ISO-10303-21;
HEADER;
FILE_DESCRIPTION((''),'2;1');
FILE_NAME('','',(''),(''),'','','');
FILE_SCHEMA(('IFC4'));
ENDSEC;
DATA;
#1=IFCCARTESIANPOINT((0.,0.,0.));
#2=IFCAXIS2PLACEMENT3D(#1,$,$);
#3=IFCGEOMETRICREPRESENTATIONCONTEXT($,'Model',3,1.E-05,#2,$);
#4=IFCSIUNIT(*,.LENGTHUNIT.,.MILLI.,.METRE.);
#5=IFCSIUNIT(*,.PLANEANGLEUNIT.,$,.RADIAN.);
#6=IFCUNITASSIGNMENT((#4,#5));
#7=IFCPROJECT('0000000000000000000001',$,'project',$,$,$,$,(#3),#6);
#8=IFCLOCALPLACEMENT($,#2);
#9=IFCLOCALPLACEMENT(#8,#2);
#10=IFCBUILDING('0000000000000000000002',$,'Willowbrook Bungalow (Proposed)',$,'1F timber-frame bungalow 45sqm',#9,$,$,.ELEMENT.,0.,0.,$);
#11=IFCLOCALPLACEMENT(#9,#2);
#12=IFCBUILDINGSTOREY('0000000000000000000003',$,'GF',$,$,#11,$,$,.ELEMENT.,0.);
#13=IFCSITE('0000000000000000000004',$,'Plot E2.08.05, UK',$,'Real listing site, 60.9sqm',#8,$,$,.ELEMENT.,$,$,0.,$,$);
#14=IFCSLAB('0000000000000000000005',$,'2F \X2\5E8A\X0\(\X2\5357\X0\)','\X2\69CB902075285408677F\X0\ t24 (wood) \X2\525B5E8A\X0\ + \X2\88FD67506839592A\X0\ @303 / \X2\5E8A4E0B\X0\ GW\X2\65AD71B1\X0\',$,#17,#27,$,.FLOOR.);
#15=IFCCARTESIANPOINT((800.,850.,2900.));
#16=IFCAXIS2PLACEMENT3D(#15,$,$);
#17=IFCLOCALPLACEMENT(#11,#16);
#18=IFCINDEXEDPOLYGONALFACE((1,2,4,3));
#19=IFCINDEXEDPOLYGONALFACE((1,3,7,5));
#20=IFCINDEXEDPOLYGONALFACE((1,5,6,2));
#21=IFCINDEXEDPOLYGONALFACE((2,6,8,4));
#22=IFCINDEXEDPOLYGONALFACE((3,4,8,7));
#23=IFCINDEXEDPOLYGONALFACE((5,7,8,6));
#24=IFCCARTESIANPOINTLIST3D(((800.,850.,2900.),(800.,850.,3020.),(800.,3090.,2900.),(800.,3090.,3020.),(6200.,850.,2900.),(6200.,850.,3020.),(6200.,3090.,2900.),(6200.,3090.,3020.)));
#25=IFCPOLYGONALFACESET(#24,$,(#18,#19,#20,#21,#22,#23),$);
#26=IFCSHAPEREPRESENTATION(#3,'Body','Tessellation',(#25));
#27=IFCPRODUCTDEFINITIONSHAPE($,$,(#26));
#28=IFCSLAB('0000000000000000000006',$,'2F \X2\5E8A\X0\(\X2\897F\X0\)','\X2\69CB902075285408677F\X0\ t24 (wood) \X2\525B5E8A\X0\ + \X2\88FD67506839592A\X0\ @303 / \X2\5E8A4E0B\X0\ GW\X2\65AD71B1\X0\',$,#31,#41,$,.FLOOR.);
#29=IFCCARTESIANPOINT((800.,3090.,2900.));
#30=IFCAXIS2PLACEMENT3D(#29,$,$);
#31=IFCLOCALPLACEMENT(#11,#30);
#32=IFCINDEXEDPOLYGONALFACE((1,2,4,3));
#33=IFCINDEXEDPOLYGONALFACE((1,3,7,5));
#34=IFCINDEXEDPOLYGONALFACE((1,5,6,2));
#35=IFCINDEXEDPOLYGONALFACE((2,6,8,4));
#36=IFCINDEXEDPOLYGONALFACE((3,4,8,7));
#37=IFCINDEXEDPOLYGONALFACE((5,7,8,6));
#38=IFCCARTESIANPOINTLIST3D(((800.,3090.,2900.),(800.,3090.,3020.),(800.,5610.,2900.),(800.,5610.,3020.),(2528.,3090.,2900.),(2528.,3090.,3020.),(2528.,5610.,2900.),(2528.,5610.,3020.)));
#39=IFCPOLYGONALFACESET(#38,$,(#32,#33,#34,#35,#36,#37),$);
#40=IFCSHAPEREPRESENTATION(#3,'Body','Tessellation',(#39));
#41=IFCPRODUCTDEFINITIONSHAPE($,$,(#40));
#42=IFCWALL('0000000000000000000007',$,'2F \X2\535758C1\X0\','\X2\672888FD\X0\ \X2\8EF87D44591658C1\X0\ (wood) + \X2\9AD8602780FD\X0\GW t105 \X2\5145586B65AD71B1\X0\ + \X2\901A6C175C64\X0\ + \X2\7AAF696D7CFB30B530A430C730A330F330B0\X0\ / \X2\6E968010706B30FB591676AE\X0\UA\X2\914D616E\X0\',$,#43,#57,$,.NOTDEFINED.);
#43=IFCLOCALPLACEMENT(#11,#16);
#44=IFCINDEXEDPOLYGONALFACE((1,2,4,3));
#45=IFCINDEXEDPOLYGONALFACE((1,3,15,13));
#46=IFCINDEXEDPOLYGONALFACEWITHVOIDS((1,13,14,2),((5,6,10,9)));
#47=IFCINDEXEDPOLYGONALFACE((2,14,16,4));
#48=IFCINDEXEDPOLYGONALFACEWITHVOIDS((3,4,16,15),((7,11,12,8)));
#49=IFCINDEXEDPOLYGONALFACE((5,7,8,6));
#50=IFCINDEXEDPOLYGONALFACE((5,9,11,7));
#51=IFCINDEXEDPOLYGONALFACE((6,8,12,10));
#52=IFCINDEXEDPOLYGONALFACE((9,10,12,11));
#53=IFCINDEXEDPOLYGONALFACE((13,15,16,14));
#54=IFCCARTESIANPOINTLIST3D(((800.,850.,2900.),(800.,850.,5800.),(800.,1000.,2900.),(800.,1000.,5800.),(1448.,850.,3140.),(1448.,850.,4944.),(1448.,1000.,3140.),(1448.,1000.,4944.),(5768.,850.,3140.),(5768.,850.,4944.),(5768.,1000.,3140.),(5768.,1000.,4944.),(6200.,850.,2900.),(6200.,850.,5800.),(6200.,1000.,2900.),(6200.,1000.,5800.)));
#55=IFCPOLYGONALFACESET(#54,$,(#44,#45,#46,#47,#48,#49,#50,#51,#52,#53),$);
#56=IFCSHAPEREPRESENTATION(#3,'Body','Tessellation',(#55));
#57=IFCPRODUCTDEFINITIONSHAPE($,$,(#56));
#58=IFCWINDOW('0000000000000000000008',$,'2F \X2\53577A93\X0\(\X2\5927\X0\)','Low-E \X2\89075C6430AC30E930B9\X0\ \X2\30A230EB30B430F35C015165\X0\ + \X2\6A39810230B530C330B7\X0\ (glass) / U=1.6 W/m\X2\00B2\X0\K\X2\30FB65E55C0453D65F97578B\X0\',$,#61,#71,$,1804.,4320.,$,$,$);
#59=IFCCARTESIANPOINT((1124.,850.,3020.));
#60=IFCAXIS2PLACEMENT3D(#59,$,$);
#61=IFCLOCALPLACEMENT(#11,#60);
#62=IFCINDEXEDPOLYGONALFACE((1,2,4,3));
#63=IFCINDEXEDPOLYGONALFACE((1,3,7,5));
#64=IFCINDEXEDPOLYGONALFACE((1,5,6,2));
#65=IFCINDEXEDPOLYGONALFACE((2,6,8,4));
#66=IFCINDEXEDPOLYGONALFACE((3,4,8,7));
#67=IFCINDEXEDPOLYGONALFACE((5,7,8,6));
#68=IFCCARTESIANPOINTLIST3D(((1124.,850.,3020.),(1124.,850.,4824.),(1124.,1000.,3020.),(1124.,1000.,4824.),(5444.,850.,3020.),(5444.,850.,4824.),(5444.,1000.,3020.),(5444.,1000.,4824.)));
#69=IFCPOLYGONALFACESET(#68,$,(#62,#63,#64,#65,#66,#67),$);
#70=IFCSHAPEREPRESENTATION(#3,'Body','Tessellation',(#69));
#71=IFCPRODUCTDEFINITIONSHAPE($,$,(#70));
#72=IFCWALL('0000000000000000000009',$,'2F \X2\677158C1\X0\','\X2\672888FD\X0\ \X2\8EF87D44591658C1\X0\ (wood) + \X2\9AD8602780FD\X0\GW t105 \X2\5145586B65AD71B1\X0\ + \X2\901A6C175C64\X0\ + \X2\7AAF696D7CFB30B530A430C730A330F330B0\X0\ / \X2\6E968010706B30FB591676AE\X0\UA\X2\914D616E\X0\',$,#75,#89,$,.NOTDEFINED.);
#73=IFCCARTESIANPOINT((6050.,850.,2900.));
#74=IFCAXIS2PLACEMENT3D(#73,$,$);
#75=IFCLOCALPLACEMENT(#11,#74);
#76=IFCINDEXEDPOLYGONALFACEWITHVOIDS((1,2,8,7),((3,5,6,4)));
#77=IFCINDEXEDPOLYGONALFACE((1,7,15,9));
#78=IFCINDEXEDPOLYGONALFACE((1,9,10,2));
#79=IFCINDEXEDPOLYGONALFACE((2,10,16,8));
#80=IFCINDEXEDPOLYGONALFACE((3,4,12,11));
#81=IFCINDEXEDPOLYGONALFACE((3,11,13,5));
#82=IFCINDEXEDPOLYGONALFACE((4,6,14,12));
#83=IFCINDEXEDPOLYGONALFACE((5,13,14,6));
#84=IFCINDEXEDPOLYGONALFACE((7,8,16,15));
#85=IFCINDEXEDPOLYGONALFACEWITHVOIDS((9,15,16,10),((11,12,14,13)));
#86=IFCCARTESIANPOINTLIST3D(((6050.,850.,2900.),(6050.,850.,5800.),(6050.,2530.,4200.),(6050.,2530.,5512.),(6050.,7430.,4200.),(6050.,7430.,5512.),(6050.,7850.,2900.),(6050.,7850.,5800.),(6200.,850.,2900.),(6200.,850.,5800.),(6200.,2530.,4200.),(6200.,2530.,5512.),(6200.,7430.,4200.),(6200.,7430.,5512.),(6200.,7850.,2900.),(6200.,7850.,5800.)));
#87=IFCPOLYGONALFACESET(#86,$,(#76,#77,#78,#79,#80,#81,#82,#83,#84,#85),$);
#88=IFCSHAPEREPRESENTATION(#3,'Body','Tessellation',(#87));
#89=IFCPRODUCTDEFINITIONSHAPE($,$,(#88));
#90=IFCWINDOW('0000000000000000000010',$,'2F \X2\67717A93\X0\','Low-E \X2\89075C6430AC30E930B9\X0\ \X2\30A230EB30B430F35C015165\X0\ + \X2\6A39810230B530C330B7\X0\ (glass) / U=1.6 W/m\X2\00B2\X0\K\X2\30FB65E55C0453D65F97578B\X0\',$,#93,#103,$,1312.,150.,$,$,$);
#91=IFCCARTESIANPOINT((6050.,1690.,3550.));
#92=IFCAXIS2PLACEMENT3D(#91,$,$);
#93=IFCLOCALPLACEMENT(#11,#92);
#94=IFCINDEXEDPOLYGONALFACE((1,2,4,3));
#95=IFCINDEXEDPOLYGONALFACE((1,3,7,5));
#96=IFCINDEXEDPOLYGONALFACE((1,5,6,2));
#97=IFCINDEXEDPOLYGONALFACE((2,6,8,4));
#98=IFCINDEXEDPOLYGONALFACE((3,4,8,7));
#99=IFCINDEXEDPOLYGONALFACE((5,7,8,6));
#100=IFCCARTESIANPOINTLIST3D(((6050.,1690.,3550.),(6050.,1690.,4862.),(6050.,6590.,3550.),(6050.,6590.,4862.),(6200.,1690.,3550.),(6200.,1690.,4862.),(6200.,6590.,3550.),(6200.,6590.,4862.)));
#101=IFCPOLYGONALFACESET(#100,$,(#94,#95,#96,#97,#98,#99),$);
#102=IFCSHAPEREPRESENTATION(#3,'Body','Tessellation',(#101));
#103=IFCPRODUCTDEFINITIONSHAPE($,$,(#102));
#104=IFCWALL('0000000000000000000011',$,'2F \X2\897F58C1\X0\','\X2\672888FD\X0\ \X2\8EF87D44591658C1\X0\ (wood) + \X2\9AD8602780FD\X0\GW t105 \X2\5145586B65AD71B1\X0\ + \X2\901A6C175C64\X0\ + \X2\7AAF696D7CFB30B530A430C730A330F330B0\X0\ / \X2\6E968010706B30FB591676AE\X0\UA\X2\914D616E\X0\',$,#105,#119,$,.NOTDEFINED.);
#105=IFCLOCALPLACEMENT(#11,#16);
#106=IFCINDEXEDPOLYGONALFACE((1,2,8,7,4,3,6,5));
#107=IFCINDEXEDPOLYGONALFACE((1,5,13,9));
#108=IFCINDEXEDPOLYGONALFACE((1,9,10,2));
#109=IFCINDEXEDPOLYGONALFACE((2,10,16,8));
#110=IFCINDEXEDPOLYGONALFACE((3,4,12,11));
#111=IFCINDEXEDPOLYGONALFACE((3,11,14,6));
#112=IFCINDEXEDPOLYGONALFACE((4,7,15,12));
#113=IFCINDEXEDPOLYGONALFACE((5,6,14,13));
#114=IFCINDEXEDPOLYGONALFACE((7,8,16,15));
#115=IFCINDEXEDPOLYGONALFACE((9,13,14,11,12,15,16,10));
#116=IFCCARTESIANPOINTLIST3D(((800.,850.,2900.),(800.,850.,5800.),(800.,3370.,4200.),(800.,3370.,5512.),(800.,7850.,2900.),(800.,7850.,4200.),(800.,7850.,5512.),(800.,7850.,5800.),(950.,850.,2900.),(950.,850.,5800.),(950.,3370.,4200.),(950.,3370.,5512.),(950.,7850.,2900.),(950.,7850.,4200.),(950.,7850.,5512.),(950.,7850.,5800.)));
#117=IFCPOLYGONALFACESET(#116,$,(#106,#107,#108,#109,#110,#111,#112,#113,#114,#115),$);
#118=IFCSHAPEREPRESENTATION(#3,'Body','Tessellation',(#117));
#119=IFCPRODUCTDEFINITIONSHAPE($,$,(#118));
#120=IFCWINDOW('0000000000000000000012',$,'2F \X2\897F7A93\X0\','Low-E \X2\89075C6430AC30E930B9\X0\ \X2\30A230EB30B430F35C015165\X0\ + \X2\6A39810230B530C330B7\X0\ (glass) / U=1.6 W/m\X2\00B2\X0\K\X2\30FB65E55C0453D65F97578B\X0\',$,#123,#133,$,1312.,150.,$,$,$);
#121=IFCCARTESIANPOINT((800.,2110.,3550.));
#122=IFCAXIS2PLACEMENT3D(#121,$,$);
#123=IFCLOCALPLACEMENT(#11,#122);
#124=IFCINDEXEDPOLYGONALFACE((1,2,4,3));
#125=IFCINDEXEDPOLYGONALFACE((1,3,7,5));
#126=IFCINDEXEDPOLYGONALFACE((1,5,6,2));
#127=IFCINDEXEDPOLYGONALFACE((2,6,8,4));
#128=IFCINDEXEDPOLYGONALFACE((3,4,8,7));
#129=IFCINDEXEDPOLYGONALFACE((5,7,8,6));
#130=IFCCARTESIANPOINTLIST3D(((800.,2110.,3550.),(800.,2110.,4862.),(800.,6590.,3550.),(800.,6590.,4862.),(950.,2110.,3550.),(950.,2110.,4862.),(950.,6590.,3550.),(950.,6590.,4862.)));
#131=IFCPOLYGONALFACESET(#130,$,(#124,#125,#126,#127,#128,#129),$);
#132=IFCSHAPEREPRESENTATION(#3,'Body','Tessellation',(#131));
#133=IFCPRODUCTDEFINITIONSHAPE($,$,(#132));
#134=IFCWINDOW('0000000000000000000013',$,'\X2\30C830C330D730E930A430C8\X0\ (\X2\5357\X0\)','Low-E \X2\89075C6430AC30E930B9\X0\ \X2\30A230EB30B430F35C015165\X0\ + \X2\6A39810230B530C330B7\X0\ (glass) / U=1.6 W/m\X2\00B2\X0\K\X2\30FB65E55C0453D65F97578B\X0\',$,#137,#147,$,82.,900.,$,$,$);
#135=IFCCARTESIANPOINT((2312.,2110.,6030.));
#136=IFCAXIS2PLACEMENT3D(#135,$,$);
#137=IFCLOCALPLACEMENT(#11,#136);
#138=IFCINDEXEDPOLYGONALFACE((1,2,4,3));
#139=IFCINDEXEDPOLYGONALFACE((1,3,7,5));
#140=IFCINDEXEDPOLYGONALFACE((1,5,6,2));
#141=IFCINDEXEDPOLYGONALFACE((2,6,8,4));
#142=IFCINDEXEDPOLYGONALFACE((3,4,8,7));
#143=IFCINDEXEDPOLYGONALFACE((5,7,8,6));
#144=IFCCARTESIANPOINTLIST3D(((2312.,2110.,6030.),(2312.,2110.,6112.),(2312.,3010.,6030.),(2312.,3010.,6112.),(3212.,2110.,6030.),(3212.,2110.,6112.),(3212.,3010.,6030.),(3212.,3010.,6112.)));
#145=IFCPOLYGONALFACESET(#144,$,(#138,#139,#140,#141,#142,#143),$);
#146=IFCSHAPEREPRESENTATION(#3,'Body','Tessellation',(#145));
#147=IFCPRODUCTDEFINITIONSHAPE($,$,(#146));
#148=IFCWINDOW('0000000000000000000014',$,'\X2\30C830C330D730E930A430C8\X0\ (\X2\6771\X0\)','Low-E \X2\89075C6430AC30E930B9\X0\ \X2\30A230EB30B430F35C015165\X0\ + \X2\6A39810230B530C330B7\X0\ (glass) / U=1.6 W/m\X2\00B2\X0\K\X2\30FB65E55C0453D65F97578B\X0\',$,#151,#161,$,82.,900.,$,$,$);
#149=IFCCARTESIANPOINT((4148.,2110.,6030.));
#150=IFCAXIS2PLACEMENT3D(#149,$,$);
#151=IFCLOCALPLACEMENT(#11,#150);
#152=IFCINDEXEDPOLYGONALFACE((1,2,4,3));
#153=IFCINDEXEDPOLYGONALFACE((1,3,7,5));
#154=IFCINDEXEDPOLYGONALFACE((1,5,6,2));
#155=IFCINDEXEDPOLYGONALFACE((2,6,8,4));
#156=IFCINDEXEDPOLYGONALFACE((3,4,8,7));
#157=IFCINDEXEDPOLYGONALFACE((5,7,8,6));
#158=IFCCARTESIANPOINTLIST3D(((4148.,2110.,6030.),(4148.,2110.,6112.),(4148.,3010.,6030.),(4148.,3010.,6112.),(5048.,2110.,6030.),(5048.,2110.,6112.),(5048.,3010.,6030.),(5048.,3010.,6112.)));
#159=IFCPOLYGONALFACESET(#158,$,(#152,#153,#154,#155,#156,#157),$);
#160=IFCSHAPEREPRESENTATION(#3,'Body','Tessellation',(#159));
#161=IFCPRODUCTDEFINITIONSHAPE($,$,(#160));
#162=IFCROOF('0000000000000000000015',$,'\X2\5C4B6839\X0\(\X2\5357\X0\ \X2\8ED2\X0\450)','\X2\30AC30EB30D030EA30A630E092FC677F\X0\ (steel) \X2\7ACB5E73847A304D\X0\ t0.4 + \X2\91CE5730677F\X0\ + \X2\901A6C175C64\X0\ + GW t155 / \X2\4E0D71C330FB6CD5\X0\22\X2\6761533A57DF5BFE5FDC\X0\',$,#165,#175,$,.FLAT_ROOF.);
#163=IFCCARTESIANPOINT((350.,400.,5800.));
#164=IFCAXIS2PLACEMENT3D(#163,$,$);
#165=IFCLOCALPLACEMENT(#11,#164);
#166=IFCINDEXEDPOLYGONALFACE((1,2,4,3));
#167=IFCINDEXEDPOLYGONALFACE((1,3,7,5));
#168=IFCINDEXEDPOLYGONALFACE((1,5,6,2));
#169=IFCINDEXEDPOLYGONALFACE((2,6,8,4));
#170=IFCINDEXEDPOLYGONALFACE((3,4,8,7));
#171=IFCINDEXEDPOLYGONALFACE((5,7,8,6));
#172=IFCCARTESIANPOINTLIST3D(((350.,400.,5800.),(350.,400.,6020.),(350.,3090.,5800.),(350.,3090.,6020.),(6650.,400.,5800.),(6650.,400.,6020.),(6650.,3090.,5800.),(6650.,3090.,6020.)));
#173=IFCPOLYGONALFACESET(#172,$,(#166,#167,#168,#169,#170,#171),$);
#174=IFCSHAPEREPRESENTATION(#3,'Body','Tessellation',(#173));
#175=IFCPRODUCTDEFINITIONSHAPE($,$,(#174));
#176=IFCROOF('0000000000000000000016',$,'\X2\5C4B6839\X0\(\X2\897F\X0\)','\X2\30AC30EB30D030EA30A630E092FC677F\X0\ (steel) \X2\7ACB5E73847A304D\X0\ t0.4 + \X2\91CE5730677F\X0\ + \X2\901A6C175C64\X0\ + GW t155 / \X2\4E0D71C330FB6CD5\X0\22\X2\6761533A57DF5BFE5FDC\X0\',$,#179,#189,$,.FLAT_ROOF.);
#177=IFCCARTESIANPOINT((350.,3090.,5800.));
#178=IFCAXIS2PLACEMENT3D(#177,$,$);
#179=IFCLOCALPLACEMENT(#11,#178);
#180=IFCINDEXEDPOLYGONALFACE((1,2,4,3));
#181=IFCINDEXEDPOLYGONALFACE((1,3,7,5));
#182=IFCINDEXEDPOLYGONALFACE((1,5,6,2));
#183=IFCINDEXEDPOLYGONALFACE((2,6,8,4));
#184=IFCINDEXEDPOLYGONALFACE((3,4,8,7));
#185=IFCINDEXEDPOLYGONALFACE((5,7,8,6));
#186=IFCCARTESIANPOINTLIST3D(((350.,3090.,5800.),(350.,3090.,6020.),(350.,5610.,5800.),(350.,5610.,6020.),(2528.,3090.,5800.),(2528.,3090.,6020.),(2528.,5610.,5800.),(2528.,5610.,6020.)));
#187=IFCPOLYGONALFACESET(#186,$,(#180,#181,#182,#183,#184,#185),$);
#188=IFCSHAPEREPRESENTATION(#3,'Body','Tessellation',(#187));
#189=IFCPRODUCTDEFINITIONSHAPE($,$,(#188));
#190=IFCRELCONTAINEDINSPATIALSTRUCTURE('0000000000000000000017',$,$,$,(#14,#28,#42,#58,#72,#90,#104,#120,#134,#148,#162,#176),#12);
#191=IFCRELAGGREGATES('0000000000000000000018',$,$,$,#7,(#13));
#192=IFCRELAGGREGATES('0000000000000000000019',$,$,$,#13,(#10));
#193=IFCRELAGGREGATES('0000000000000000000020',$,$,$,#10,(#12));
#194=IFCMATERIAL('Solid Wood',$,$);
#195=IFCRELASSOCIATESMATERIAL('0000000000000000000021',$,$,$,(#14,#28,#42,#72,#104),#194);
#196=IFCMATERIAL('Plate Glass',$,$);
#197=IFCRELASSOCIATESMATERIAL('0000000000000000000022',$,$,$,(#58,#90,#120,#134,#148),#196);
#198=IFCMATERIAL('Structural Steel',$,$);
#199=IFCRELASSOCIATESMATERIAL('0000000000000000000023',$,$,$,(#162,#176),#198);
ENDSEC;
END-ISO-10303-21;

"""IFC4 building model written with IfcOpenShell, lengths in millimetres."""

from ifc_helpers import new_model, si_unit, frame, frame_2d, origin, place, context, project, spatial, rectangle, extrude, material, element, fill, save


model = new_model("IFC4")

# Units and contexts
model_context = context("Model", 3, precision=1e-05, world=origin())
ifc_project = project(units=[si_unit("LENGTHUNIT", "METRE", prefix="MILLI"), si_unit("PLANEANGLEUNIT", "RADIAN")], contexts=[model_context])

# Site, building, storey
site_placement = place(None, origin())
site = spatial("IfcSite", under=ifc_project, at=site_placement, Name="Plot E2.08.05, UK", ObjectType="Real listing site, 60.9sqm", CompositionType="ELEMENT", RefElevation=0.0)
building_placement = place(site_placement, origin())
building = spatial("IfcBuilding", under=site, at=building_placement, Name="Willowbrook Bungalow (Proposed)", ObjectType="1F timber-frame bungalow 45sqm", CompositionType="ELEMENT", ElevationOfRefHeight=0.0, ElevationOfTerrain=0.0)
storey_placement = place(building_placement, origin())
storey = spatial("IfcBuildingStorey", under=building, at=storey_placement, Name="GF", CompositionType="ELEMENT", Elevation=0.0)

# Slabs
ifc_material_1 = material(Name="Solid Wood")
slab_1_placement = place(storey_placement, frame((800.0, 850.0, 2900.0)))
element("IfcSlab", 1, at=slab_1_placement, inside=storey, material=ifc_material_1, Name="2F 床(南)", Description="構造用合板 t24 (wood) 剛床 + 製材根太 @303 / 床下 GW断熱", PredefinedType="FLOOR", context=model_context, shape_type="SweptSolid", body=[
    extrude(rectangle(XDim=5400.0, YDim=2240.0, at=frame_2d((2700.0, 1120.0))), frame((800.0, 850.0, 2900.0)), (0.0, 0.0, 1.0), 120.0),
])
slab_2_placement = place(storey_placement, frame((800.0, 3090.0, 2900.0)))
element("IfcSlab", 2, at=slab_2_placement, inside=storey, material=ifc_material_1, Name="2F 床(西)", Description="構造用合板 t24 (wood) 剛床 + 製材根太 @303 / 床下 GW断熱", PredefinedType="FLOOR", context=model_context, shape_type="SweptSolid", body=[
    extrude(rectangle(XDim=1728.0, YDim=2520.0, at=frame_2d((864.0, 1260.0))), frame((800.0, 3090.0, 2900.0)), (0.0, 0.0, 1.0), 120.0),
])

# Walls, openings, windows
wall_1_placement = place(storey_placement, frame((800.0, 850.0, 2900.0)))
wall_1 = element("IfcWall", 3, at=wall_1_placement, inside=storey, material=ifc_material_1, Name="2F 南壁", Description="木製 軸組外壁 (wood) + 高性能GW t105 充填断熱 + 通気層 + 窯業系サイディング / 準耐火・外皮UA配慮", PredefinedType="NOTDEFINED", context=model_context, shape_type="SweptSolid", body=[
    extrude(rectangle(XDim=5400.0, YDim=150.0, at=frame_2d((2700.0, 75.0))), frame((800.0, 850.0, 2900.0)), (0.0, 0.0, 1.0), 2900.0),
])
opening_1_placement = place(storey_placement, frame((1124.0, 850.0, 3020.0)))
opening_1 = element("IfcOpeningElement", 4, at=opening_1_placement, cuts=wall_1, PredefinedType="NOTDEFINED", context=model_context, shape_type="SweptSolid", body=[
    extrude(rectangle(XDim=4320.0, YDim=150.0, at=frame_2d((2160.0, 75.0))), frame((1124.0, 850.0, 3020.0)), (0.0, 0.0, 1.0), 1804.0),
])
ifc_material_2 = material(Name="Plate Glass")
window_1_placement = place(storey_placement, frame((1124.0, 850.0, 3020.0)))
window_1 = element("IfcWindow", 5, at=window_1_placement, inside=storey, material=ifc_material_2, Name="2F 南窓(大)", Description="Low-E 複層ガラス アルゴン封入 + 樹脂サッシ (glass) / U=1.6 W/m²K・日射取得型", OverallHeight=1804.0, OverallWidth=4320.0, context=model_context, shape_type="SweptSolid", body=[
    extrude(rectangle(XDim=4320.0, YDim=150.0, at=frame_2d((2160.0, 75.0))), frame((1124.0, 850.0, 3020.0)), (0.0, 0.0, 1.0), 1804.0),
])
fill(opening_1, window_1)
wall_2_placement = place(storey_placement, frame((6050.0, 850.0, 2900.0)))
wall_2 = element("IfcWall", 6, at=wall_2_placement, inside=storey, material=ifc_material_1, Name="2F 東壁", Description="木製 軸組外壁 (wood) + 高性能GW t105 充填断熱 + 通気層 + 窯業系サイディング / 準耐火・外皮UA配慮", PredefinedType="NOTDEFINED", context=model_context, shape_type="SweptSolid", body=[
    extrude(rectangle(XDim=150.0, YDim=7000.0, at=frame_2d((75.0, 3500.0))), frame((6050.0, 850.0, 2900.0)), (0.0, 0.0, 1.0), 2900.0),
])
opening_2_placement = place(storey_placement, frame((6050.0, 1690.0, 3550.0)))
opening_2 = element("IfcOpeningElement", 7, at=opening_2_placement, cuts=wall_2, PredefinedType="NOTDEFINED", context=model_context, shape_type="SweptSolid", body=[
    extrude(rectangle(XDim=150.0, YDim=4900.0, at=frame_2d((75.0, 2450.0))), frame((6050.0, 1690.0, 3550.0)), (0.0, 0.0, 1.0), 1312.0),
])
window_2_placement = place(storey_placement, frame((6050.0, 1690.0, 3550.0)))
window_2 = element("IfcWindow", 8, at=window_2_placement, inside=storey, material=ifc_material_2, Name="2F 東窓", Description="Low-E 複層ガラス アルゴン封入 + 樹脂サッシ (glass) / U=1.6 W/m²K・日射取得型", OverallHeight=1312.0, OverallWidth=150.0, context=model_context, shape_type="SweptSolid", body=[
    extrude(rectangle(XDim=150.0, YDim=4900.0, at=frame_2d((75.0, 2450.0))), frame((6050.0, 1690.0, 3550.0)), (0.0, 0.0, 1.0), 1312.0),
])
fill(opening_2, window_2)
wall_3_placement = place(storey_placement, frame((800.0, 850.0, 2900.0)))
wall_3 = element("IfcWall", 9, at=wall_3_placement, inside=storey, material=ifc_material_1, Name="2F 西壁", Description="木製 軸組外壁 (wood) + 高性能GW t105 充填断熱 + 通気層 + 窯業系サイディング / 準耐火・外皮UA配慮", PredefinedType="NOTDEFINED", context=model_context, shape_type="SweptSolid", body=[
    extrude(rectangle(XDim=150.0, YDim=7000.0, at=frame_2d((75.0, 3500.0))), frame((800.0, 850.0, 2900.0)), (0.0, 0.0, 1.0), 2900.0),
])
opening_3_placement = place(storey_placement, frame((800.0, 2110.0, 3550.0)))
opening_3 = element("IfcOpeningElement", 10, at=opening_3_placement, cuts=wall_3, PredefinedType="NOTDEFINED", context=model_context, shape_type="SweptSolid", body=[
    extrude(rectangle(XDim=150.0, YDim=4480.0, at=frame_2d((75.0, 2240.0))), frame((800.0, 2110.0, 3550.0)), (0.0, 0.0, 1.0), 1312.0),
])
window_3_placement = place(storey_placement, frame((800.0, 2110.0, 3550.0)))
window_3 = element("IfcWindow", 11, at=window_3_placement, inside=storey, material=ifc_material_2, Name="2F 西窓", Description="Low-E 複層ガラス アルゴン封入 + 樹脂サッシ (glass) / U=1.6 W/m²K・日射取得型", OverallHeight=1312.0, OverallWidth=150.0, context=model_context, shape_type="SweptSolid", body=[
    extrude(rectangle(XDim=150.0, YDim=4480.0, at=frame_2d((75.0, 2240.0))), frame((800.0, 2110.0, 3550.0)), (0.0, 0.0, 1.0), 1312.0),
])
fill(opening_3, window_3)

# Windows
window_4_placement = place(storey_placement, frame((2312.0, 2110.0, 6030.0)))
element("IfcWindow", 12, at=window_4_placement, inside=storey, material=ifc_material_2, Name="トップライト (南)", Description="Low-E 複層ガラス アルゴン封入 + 樹脂サッシ (glass) / U=1.6 W/m²K・日射取得型", OverallHeight=82.0, OverallWidth=900.0, context=model_context, shape_type="SweptSolid", body=[
    extrude(rectangle(XDim=900.0, YDim=900.0, at=frame_2d((450.0, 450.0))), frame((2312.0, 2110.0, 6030.0)), (0.0, 0.0, 1.0), 82.0),
])
window_5_placement = place(storey_placement, frame((4148.0, 2110.0, 6030.0)))
element("IfcWindow", 13, at=window_5_placement, inside=storey, material=ifc_material_2, Name="トップライト (東)", Description="Low-E 複層ガラス アルゴン封入 + 樹脂サッシ (glass) / U=1.6 W/m²K・日射取得型", OverallHeight=82.0, OverallWidth=900.0, context=model_context, shape_type="SweptSolid", body=[
    extrude(rectangle(XDim=900.0, YDim=900.0, at=frame_2d((450.0, 450.0))), frame((4148.0, 2110.0, 6030.0)), (0.0, 0.0, 1.0), 82.0),
])

# Roofs
ifc_material_3 = material(Name="Structural Steel")
roof_1_placement = place(storey_placement, frame((350.0, 400.0, 5800.0)))
element("IfcRoof", 14, at=roof_1_placement, inside=storey, material=ifc_material_3, Name="屋根(南 軒450)", Description="ガルバリウム鋼板 (steel) 立平葺き t0.4 + 野地板 + 通気層 + GW t155 / 不燃・法22条区域対応", PredefinedType="FLAT_ROOF", context=model_context, shape_type="SweptSolid", body=[
    extrude(rectangle(XDim=6300.0, YDim=2690.0, at=frame_2d((3150.0, 1345.0))), frame((350.0, 400.0, 5800.0)), (0.0, 0.0, 1.0), 220.0),
])
roof_2_placement = place(storey_placement, frame((350.0, 3090.0, 5800.0)))
element("IfcRoof", 15, at=roof_2_placement, inside=storey, material=ifc_material_3, Name="屋根(西)", Description="ガルバリウム鋼板 (steel) 立平葺き t0.4 + 野地板 + 通気層 + GW t155 / 不燃・法22条区域対応", PredefinedType="FLAT_ROOF", context=model_context, shape_type="SweptSolid", body=[
    extrude(rectangle(XDim=2178.0, YDim=2520.0, at=frame_2d((1089.0, 1260.0))), frame((350.0, 3090.0, 5800.0)), (0.0, 0.0, 1.0), 220.0),
])

save(model, "model.ifc")
